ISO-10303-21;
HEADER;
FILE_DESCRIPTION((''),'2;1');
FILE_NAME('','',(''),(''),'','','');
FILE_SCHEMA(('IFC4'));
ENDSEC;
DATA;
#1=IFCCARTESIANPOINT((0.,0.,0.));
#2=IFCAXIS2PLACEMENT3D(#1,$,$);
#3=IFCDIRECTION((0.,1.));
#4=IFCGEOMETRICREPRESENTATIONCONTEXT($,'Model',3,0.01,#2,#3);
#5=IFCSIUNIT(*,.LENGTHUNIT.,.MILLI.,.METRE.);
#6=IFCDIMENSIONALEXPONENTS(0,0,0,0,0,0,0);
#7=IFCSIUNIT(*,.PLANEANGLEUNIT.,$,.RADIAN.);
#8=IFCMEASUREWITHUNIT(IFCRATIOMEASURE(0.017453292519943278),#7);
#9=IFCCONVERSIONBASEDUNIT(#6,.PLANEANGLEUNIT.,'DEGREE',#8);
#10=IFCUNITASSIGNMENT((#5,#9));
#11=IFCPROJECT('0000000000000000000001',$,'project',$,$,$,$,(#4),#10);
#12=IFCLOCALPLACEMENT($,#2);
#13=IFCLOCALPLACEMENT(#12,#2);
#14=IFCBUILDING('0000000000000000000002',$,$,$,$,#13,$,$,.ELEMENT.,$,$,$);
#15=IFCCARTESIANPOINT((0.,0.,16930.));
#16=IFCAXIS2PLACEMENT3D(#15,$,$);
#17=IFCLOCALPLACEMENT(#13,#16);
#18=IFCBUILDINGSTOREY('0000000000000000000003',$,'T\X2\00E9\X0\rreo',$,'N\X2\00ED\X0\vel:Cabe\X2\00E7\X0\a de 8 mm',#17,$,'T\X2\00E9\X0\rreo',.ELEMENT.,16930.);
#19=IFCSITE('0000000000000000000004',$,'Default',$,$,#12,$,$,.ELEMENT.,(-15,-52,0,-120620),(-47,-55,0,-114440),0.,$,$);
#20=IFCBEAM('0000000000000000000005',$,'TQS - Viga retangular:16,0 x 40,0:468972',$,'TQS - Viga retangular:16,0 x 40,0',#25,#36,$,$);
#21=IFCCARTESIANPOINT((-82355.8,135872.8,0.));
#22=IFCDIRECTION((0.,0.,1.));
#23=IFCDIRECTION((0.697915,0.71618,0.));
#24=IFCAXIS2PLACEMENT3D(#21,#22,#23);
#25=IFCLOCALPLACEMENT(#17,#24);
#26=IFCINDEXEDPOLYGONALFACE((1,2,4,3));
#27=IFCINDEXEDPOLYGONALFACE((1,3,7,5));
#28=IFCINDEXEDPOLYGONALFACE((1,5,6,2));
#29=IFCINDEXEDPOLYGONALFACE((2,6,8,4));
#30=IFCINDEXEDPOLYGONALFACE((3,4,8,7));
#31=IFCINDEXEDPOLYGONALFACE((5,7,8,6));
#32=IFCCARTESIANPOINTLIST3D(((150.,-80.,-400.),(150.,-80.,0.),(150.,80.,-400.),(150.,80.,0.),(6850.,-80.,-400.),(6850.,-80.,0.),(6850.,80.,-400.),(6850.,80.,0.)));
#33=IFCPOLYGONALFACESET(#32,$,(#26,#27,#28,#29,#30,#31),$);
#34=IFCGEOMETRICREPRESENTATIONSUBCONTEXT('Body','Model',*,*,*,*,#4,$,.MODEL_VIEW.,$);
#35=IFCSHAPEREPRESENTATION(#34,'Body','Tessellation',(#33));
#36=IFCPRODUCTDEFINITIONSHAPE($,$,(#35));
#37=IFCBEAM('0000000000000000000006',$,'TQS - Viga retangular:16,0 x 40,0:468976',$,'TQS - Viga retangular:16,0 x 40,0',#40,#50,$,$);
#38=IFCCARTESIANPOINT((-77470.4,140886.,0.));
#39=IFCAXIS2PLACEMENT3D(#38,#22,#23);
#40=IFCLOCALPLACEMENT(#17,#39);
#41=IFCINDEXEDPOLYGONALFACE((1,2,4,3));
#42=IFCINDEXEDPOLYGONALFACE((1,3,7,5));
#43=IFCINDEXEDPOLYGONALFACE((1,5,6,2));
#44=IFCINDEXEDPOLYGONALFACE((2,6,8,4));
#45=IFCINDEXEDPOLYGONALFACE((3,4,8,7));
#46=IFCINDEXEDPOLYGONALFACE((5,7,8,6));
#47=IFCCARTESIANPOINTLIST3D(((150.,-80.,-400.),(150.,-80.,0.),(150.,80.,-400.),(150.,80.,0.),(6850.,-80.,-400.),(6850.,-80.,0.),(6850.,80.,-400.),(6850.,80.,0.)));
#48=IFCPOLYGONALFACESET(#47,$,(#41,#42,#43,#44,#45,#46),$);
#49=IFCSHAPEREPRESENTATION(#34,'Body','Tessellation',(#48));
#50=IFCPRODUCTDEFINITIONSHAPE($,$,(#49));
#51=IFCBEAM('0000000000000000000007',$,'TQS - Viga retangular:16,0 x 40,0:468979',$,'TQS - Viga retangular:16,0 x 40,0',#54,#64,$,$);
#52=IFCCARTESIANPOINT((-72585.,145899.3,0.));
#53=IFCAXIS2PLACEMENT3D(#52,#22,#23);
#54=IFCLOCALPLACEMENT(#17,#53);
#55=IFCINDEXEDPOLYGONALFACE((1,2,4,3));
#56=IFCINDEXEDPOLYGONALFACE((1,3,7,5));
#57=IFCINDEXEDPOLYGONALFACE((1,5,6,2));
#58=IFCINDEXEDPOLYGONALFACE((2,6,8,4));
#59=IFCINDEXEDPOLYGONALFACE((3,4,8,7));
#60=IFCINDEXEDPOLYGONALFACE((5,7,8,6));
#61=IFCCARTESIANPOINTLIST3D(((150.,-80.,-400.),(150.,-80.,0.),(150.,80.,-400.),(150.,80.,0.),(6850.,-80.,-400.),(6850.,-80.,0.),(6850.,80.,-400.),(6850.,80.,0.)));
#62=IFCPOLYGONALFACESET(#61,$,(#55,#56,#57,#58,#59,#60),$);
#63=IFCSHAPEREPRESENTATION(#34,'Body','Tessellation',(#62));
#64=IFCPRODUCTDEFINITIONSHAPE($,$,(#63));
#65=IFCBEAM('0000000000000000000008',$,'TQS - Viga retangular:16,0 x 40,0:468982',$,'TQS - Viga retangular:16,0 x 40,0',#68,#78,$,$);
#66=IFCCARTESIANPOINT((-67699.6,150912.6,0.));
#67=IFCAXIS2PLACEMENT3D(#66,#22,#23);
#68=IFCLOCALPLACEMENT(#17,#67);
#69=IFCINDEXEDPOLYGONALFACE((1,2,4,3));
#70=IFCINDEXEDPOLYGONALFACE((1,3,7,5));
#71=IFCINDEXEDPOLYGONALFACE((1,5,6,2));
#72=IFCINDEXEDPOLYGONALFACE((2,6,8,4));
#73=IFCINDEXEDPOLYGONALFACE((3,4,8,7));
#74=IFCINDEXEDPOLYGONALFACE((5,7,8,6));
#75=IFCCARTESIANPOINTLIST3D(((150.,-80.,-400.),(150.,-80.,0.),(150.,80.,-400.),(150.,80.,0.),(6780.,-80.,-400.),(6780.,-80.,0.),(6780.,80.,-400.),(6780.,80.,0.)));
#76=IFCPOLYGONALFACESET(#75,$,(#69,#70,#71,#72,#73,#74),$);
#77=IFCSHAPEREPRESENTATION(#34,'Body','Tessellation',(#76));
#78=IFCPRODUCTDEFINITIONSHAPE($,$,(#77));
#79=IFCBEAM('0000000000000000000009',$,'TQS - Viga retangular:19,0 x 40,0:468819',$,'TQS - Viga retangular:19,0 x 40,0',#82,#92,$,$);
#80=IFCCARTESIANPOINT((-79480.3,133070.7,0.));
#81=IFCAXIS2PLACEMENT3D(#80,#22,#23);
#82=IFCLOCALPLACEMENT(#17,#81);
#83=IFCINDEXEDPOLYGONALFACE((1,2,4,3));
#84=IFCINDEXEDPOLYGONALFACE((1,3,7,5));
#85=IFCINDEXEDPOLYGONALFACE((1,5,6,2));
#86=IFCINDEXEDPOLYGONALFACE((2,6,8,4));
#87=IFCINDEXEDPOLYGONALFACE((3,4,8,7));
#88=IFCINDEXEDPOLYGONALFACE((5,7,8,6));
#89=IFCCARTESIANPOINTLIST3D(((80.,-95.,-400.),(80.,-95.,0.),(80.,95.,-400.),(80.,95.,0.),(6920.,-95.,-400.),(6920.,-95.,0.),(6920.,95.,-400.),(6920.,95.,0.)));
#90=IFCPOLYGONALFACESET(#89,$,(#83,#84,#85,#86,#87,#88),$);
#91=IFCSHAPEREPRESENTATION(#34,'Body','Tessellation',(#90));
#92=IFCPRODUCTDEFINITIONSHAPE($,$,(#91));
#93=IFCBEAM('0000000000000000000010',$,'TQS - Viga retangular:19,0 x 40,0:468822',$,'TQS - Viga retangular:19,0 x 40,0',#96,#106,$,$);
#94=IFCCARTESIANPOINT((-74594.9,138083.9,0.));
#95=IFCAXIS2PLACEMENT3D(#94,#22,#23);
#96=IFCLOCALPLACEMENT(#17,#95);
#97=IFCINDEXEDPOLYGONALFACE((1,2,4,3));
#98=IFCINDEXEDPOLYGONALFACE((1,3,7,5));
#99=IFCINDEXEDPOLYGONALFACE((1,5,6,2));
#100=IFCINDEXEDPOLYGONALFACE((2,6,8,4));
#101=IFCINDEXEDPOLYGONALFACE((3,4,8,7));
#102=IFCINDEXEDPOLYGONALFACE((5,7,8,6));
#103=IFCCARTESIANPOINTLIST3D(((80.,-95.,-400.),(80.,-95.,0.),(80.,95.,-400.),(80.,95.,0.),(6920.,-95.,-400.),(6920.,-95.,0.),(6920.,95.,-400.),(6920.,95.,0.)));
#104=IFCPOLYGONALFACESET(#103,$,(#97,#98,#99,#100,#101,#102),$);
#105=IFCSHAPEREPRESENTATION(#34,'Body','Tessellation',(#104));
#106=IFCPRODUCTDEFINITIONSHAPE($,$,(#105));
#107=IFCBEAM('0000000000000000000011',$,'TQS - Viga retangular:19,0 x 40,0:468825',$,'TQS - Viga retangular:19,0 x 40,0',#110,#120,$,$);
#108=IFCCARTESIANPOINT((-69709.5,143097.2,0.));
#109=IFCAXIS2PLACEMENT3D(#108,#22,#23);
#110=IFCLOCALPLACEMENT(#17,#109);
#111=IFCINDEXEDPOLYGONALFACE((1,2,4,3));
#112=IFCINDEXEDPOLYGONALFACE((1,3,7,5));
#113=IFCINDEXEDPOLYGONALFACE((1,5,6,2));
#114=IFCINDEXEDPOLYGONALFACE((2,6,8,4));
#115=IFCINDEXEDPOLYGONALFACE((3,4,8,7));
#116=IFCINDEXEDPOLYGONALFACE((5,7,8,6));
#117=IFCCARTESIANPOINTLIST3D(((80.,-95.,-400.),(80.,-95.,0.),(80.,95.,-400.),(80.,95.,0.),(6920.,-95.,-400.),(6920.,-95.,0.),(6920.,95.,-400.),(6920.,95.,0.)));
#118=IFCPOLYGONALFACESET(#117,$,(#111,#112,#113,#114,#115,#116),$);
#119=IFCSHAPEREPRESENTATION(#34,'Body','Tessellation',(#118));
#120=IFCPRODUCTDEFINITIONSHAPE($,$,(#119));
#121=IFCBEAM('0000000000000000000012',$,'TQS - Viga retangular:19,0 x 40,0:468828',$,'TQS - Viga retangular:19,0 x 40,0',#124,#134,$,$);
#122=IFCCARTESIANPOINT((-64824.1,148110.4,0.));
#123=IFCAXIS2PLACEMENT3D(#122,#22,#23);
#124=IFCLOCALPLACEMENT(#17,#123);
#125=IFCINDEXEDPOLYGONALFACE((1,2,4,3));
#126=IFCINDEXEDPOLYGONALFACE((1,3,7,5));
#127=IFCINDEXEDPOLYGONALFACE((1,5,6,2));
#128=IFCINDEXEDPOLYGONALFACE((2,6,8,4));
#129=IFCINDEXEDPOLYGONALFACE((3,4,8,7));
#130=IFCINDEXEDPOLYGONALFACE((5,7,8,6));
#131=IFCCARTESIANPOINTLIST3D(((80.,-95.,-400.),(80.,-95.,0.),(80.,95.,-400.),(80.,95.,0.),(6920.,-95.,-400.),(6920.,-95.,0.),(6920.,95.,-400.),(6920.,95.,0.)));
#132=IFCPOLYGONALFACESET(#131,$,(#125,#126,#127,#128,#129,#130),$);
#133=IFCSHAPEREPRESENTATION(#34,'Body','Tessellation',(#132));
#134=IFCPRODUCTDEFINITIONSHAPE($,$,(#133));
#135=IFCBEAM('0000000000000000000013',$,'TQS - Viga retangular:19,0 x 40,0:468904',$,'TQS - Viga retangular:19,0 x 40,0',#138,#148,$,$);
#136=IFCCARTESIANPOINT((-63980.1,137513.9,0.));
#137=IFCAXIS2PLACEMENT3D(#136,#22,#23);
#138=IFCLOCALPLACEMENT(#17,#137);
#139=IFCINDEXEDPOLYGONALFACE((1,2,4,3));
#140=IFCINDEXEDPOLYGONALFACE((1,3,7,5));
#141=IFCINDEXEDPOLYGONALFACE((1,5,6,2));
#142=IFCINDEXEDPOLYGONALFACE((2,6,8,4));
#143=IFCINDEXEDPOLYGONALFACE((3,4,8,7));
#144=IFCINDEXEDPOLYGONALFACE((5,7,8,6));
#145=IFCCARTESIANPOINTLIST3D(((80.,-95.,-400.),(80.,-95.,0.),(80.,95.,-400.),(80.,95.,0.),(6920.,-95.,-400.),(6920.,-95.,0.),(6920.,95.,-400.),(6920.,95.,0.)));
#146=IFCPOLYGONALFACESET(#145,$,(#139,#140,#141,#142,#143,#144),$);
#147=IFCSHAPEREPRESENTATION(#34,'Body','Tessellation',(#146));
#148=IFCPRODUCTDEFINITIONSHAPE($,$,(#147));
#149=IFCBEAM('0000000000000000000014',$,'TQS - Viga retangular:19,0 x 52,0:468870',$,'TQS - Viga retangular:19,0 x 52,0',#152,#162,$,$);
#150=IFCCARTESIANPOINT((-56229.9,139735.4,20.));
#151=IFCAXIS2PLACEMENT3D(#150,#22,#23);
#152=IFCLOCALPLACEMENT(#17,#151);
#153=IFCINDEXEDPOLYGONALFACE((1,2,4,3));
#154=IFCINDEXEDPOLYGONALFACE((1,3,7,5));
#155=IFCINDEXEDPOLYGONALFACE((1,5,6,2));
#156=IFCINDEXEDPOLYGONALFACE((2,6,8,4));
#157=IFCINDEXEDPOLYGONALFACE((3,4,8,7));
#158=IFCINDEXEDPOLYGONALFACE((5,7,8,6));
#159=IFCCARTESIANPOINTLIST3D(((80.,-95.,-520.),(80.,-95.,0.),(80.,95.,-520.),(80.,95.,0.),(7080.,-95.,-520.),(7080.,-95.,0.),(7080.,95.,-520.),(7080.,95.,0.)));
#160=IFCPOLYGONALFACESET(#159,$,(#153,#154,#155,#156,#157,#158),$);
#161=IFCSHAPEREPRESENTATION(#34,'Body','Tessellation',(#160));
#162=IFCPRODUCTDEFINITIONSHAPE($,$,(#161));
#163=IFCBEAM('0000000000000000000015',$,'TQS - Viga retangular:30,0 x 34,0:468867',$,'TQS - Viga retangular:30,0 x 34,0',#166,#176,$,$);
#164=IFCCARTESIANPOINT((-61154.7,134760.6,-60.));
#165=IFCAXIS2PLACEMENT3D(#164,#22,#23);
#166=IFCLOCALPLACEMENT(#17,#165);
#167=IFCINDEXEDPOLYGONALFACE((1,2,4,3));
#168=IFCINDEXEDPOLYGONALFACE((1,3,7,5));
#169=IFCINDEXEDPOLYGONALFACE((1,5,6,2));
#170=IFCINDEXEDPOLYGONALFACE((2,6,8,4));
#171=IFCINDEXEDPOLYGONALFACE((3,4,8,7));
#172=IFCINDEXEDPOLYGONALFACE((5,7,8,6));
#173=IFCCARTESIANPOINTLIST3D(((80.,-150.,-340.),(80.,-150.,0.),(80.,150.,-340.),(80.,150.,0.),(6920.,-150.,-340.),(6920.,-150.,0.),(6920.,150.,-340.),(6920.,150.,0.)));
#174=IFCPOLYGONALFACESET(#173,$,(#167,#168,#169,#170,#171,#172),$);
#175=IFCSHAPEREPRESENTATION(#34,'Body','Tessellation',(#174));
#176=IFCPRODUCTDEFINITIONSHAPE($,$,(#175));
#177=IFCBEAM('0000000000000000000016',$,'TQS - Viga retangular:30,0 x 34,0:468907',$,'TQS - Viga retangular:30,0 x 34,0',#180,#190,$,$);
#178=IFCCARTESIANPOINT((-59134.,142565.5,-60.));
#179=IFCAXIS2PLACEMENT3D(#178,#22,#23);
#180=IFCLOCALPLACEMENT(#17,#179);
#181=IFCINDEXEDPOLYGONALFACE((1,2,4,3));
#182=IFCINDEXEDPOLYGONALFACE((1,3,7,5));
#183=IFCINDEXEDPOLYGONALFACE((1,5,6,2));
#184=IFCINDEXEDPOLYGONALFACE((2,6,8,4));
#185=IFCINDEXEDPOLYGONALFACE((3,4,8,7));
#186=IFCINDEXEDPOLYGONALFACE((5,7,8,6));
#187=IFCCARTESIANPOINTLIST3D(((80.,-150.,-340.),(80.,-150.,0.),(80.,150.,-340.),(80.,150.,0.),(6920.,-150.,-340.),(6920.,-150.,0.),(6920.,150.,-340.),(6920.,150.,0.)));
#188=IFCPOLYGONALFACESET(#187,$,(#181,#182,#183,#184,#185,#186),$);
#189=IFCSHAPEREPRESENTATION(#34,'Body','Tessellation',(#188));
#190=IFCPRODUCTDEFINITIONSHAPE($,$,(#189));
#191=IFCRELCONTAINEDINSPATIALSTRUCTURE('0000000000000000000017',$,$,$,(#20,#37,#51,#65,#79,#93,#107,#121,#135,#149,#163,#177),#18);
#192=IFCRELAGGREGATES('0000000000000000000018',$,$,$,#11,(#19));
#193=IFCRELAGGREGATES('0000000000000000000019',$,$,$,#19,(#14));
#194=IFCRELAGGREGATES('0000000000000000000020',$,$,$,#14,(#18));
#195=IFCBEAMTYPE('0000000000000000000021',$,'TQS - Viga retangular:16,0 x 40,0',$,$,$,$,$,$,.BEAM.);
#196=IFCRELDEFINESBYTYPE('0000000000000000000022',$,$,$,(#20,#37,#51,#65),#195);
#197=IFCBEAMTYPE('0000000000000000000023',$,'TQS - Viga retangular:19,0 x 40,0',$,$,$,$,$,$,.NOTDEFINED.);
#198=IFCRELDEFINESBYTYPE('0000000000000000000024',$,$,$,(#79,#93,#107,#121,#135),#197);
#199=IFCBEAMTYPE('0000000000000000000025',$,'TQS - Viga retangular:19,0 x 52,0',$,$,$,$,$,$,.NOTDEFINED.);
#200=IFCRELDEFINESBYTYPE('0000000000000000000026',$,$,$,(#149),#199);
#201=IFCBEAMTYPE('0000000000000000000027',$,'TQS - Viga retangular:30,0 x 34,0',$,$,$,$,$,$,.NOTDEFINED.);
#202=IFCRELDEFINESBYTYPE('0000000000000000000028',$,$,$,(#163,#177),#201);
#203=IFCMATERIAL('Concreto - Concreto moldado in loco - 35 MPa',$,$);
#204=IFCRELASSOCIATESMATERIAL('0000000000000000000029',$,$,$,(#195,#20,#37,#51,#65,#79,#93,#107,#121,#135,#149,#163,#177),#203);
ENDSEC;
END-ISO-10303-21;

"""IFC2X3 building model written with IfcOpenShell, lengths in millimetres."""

from ifc_helpers import new_model, entity, si_unit, converted_unit, direction, frame, frame_2d, origin, origin_2d_with_axis, place, context, subcontext, project, spatial, rectangle, extrude, material, type_object, element, save


model = new_model("IFC2X3")

# Units and contexts
model_context = context("Model", 3, precision=0.01, world=origin(), true_north=direction((0.0, 1.0)))
body_context = subcontext(model_context, "Body", "Model", "MODEL_VIEW")
ifc_project = project(units=[si_unit("LENGTHUNIT", "METRE", prefix="MILLI"), converted_unit("PLANEANGLEUNIT", "DEGREE", entity("IfcRatioMeasure", 0.017453292519943278), si_unit("PLANEANGLEUNIT", "RADIAN"), dimensions=[0, 0, 0, 0, 0, 0, 0])], contexts=[model_context])

# Site, building, storey
site_placement = place(None, origin())
site = spatial("IfcSite", under=ifc_project, at=site_placement, Name="Default", CompositionType="ELEMENT", RefLatitude=(-15, -52, 0, -120620), RefLongitude=(-47, -55, 0, -114440), RefElevation=0.0)
building_placement = place(site_placement, origin())
building = spatial("IfcBuilding", under=site, at=building_placement, CompositionType="ELEMENT")
storey_placement = place(building_placement, frame((0.0, 0.0, 16930.0)))
storey = spatial("IfcBuildingStorey", under=building, at=storey_placement, Name="Térreo", ObjectType="Nível:Cabeça de 8 mm", LongName="Térreo", CompositionType="ELEMENT", Elevation=16930.0)

# Beams
ifc_material_1 = material(Name="Concreto - Concreto moldado in loco - 35 MPa")
beam_type_1 = type_object("IfcBeamType", Name="TQS - Viga retangular:16,0 x 40,0", PredefinedType="BEAM", material=ifc_material_1)
beam_1_placement = place(storey_placement, frame((-82355.8, 135872.8, 0.0), z_axis=(0.0, 0.0, 1.0), x_axis=(0.697915, 0.71618, 0.0)))
element("IfcBeam", 1, at=beam_1_placement, inside=storey, type_object=beam_type_1, material=ifc_material_1, Name="TQS - Viga retangular:16,0 x 40,0:468972", ObjectType="TQS - Viga retangular:16,0 x 40,0", context=body_context, shape_type="SweptSolid", body=[
    extrude(rectangle(XDim=400.0, YDim=160.0, at=origin_2d_with_axis()), frame((150.0, 0.0, -200.0), z_axis=(1.0, 0.0, 0.0), x_axis=(0.0, 0.0, -1.0)), (0.0, 0.0, 1.0), 6700.0),
])
beam_2_placement = place(storey_placement, frame((-77470.4, 140886.0, 0.0), z_axis=(0.0, 0.0, 1.0), x_axis=(0.697915, 0.71618, 0.0)))
element("IfcBeam", 2, at=beam_2_placement, inside=storey, type_object=beam_type_1, material=ifc_material_1, Name="TQS - Viga retangular:16,0 x 40,0:468976", ObjectType="TQS - Viga retangular:16,0 x 40,0", context=body_context, shape_type="SweptSolid", body=[
    extrude(rectangle(XDim=400.0, YDim=160.0, at=frame_2d((0.0, 0.0), x_axis=(1.0, 0.0))), frame((150.0, 0.0, -200.0), z_axis=(1.0, 0.0, 0.0), x_axis=(0.0, 0.0, -1.0)), (0.0, 0.0, 1.0), 6700.0),
])
beam_3_placement = place(storey_placement, frame((-72585.0, 145899.3, 0.0), z_axis=(0.0, 0.0, 1.0), x_axis=(0.697915, 0.71618, 0.0)))
element("IfcBeam", 3, at=beam_3_placement, inside=storey, type_object=beam_type_1, material=ifc_material_1, Name="TQS - Viga retangular:16,0 x 40,0:468979", ObjectType="TQS - Viga retangular:16,0 x 40,0", context=body_context, shape_type="SweptSolid", body=[
    extrude(rectangle(XDim=400.0, YDim=160.0, at=frame_2d((0.0, 0.0), x_axis=(1.0, 0.0))), frame((150.0, 0.0, -200.0), z_axis=(1.0, 0.0, 0.0), x_axis=(0.0, 0.0, -1.0)), (0.0, 0.0, 1.0), 6700.0),
])
beam_4_placement = place(storey_placement, frame((-67699.6, 150912.6, 0.0), z_axis=(0.0, 0.0, 1.0), x_axis=(0.697915, 0.71618, 0.0)))
element("IfcBeam", 4, at=beam_4_placement, inside=storey, type_object=beam_type_1, material=ifc_material_1, Name="TQS - Viga retangular:16,0 x 40,0:468982", ObjectType="TQS - Viga retangular:16,0 x 40,0", context=body_context, shape_type="SweptSolid", body=[
    extrude(rectangle(XDim=400.0, YDim=160.0, at=frame_2d((0.0, 0.0), x_axis=(1.0, 0.0))), frame((150.0, 0.0, -200.0), z_axis=(1.0, 0.0, 0.0), x_axis=(0.0, 0.0, -1.0)), (0.0, 0.0, 1.0), 6630.0),
])
beam_type_2 = type_object("IfcBeamType", Name="TQS - Viga retangular:19,0 x 40,0", PredefinedType="NOTDEFINED")
beam_5_placement = place(storey_placement, frame((-79480.3, 133070.7, 0.0), z_axis=(0.0, 0.0, 1.0), x_axis=(0.697915, 0.71618, 0.0)))
element("IfcBeam", 5, at=beam_5_placement, inside=storey, type_object=beam_type_2, material=ifc_material_1, Name="TQS - Viga retangular:19,0 x 40,0:468819", ObjectType="TQS - Viga retangular:19,0 x 40,0", context=body_context, shape_type="SweptSolid", body=[
    extrude(rectangle(XDim=400.0, YDim=190.0, at=frame_2d((0.0, 0.0), x_axis=(1.0, 0.0))), frame((80.0, 0.0, -200.0), z_axis=(1.0, 0.0, 0.0), x_axis=(0.0, 0.0, -1.0)), (0.0, 0.0, 1.0), 6840.0),
])
beam_6_placement = place(storey_placement, frame((-74594.9, 138083.9, 0.0), z_axis=(0.0, 0.0, 1.0), x_axis=(0.697915, 0.71618, 0.0)))
element("IfcBeam", 6, at=beam_6_placement, inside=storey, type_object=beam_type_2, material=ifc_material_1, Name="TQS - Viga retangular:19,0 x 40,0:468822", ObjectType="TQS - Viga retangular:19,0 x 40,0", context=body_context, shape_type="SweptSolid", body=[
    extrude(rectangle(XDim=400.0, YDim=190.0, at=frame_2d((0.0, 0.0), x_axis=(1.0, 0.0))), frame((80.0, 0.0, -200.0), z_axis=(1.0, 0.0, 0.0), x_axis=(0.0, 0.0, -1.0)), (0.0, 0.0, 1.0), 6840.0),
])
beam_7_placement = place(storey_placement, frame((-69709.5, 143097.2, 0.0), z_axis=(0.0, 0.0, 1.0), x_axis=(0.697915, 0.71618, 0.0)))
element("IfcBeam", 7, at=beam_7_placement, inside=storey, type_object=beam_type_2, material=ifc_material_1, Name="TQS - Viga retangular:19,0 x 40,0:468825", ObjectType="TQS - Viga retangular:19,0 x 40,0", context=body_context, shape_type="SweptSolid", body=[
    extrude(rectangle(XDim=400.0, YDim=190.0, at=frame_2d((0.0, 0.0), x_axis=(1.0, 0.0))), frame((80.0, 0.0, -200.0), z_axis=(1.0, 0.0, 0.0), x_axis=(0.0, 0.0, -1.0)), (0.0, 0.0, 1.0), 6840.0),
])
beam_8_placement = place(storey_placement, frame((-64824.1, 148110.4, 0.0), z_axis=(0.0, 0.0, 1.0), x_axis=(0.697915, 0.71618, 0.0)))
element("IfcBeam", 8, at=beam_8_placement, inside=storey, type_object=beam_type_2, material=ifc_material_1, Name="TQS - Viga retangular:19,0 x 40,0:468828", ObjectType="TQS - Viga retangular:19,0 x 40,0", context=body_context, shape_type="SweptSolid", body=[
    extrude(rectangle(XDim=400.0, YDim=190.0, at=frame_2d((0.0, 0.0), x_axis=(1.0, 0.0))), frame((80.0, 0.0, -200.0), z_axis=(1.0, 0.0, 0.0), x_axis=(0.0, 0.0, -1.0)), (0.0, 0.0, 1.0), 6840.0),
])
beam_9_placement = place(storey_placement, frame((-63980.1, 137513.9, 0.0), z_axis=(0.0, 0.0, 1.0), x_axis=(0.697915, 0.71618, 0.0)))
element("IfcBeam", 9, at=beam_9_placement, inside=storey, type_object=beam_type_2, material=ifc_material_1, Name="TQS - Viga retangular:19,0 x 40,0:468904", ObjectType="TQS - Viga retangular:19,0 x 40,0", context=body_context, shape_type="SweptSolid", body=[
    extrude(rectangle(XDim=400.0, YDim=190.0, at=origin_2d_with_axis()), frame((80.0, 0.0, -200.0), z_axis=(1.0, 0.0, 0.0), x_axis=(0.0, 0.0, -1.0)), (0.0, 0.0, 1.0), 6840.0),
])
beam_type_3 = type_object("IfcBeamType", Name="TQS - Viga retangular:19,0 x 52,0", PredefinedType="NOTDEFINED")
beam_10_placement = place(storey_placement, frame((-56229.9, 139735.4, 20.0), z_axis=(0.0, 0.0, 1.0), x_axis=(0.697915, 0.71618, 0.0)))
element("IfcBeam", 10, at=beam_10_placement, inside=storey, type_object=beam_type_3, material=ifc_material_1, Name="TQS - Viga retangular:19,0 x 52,0:468870", ObjectType="TQS - Viga retangular:19,0 x 52,0", context=body_context, shape_type="SweptSolid", body=[
    extrude(rectangle(XDim=520.0, YDim=190.0, at=frame_2d((0.0, 0.0), x_axis=(1.0, 0.0))), frame((80.0, 0.0, -260.0), z_axis=(1.0, 0.0, 0.0), x_axis=(0.0, 0.0, -1.0)), (0.0, 0.0, 1.0), 7000.0),
])
beam_type_4 = type_object("IfcBeamType", Name="TQS - Viga retangular:30,0 x 34,0", PredefinedType="NOTDEFINED")
beam_11_placement = place(storey_placement, frame((-61154.7, 134760.6, -60.0), z_axis=(0.0, 0.0, 1.0), x_axis=(0.697915, 0.71618, 0.0)))
element("IfcBeam", 11, at=beam_11_placement, inside=storey, type_object=beam_type_4, material=ifc_material_1, Name="TQS - Viga retangular:30,0 x 34,0:468867", ObjectType="TQS - Viga retangular:30,0 x 34,0", context=body_context, shape_type="SweptSolid", body=[
    extrude(rectangle(XDim=340.0, YDim=300.0, at=frame_2d((0.0, 0.0), x_axis=(1.0, 0.0))), frame((80.0, 0.0, -170.0), z_axis=(1.0, 0.0, 0.0), x_axis=(0.0, 0.0, -1.0)), (0.0, 0.0, 1.0), 6840.0),
])
beam_12_placement = place(storey_placement, frame((-59134.0, 142565.5, -60.0), z_axis=(0.0, 0.0, 1.0), x_axis=(0.697915, 0.71618, 0.0)))
element("IfcBeam", 12, at=beam_12_placement, inside=storey, type_object=beam_type_4, material=ifc_material_1, Name="TQS - Viga retangular:30,0 x 34,0:468907", ObjectType="TQS - Viga retangular:30,0 x 34,0", context=body_context, shape_type="SweptSolid", body=[
    extrude(rectangle(XDim=340.0, YDim=300.0, at=frame_2d((0.0, 0.0), x_axis=(1.0, 0.0))), frame((80.0, 0.0, -170.0), z_axis=(1.0, 0.0, 0.0), x_axis=(0.0, 0.0, -1.0)), (0.0, 0.0, 1.0), 6840.0),
])

save(model, "model.ifc")
